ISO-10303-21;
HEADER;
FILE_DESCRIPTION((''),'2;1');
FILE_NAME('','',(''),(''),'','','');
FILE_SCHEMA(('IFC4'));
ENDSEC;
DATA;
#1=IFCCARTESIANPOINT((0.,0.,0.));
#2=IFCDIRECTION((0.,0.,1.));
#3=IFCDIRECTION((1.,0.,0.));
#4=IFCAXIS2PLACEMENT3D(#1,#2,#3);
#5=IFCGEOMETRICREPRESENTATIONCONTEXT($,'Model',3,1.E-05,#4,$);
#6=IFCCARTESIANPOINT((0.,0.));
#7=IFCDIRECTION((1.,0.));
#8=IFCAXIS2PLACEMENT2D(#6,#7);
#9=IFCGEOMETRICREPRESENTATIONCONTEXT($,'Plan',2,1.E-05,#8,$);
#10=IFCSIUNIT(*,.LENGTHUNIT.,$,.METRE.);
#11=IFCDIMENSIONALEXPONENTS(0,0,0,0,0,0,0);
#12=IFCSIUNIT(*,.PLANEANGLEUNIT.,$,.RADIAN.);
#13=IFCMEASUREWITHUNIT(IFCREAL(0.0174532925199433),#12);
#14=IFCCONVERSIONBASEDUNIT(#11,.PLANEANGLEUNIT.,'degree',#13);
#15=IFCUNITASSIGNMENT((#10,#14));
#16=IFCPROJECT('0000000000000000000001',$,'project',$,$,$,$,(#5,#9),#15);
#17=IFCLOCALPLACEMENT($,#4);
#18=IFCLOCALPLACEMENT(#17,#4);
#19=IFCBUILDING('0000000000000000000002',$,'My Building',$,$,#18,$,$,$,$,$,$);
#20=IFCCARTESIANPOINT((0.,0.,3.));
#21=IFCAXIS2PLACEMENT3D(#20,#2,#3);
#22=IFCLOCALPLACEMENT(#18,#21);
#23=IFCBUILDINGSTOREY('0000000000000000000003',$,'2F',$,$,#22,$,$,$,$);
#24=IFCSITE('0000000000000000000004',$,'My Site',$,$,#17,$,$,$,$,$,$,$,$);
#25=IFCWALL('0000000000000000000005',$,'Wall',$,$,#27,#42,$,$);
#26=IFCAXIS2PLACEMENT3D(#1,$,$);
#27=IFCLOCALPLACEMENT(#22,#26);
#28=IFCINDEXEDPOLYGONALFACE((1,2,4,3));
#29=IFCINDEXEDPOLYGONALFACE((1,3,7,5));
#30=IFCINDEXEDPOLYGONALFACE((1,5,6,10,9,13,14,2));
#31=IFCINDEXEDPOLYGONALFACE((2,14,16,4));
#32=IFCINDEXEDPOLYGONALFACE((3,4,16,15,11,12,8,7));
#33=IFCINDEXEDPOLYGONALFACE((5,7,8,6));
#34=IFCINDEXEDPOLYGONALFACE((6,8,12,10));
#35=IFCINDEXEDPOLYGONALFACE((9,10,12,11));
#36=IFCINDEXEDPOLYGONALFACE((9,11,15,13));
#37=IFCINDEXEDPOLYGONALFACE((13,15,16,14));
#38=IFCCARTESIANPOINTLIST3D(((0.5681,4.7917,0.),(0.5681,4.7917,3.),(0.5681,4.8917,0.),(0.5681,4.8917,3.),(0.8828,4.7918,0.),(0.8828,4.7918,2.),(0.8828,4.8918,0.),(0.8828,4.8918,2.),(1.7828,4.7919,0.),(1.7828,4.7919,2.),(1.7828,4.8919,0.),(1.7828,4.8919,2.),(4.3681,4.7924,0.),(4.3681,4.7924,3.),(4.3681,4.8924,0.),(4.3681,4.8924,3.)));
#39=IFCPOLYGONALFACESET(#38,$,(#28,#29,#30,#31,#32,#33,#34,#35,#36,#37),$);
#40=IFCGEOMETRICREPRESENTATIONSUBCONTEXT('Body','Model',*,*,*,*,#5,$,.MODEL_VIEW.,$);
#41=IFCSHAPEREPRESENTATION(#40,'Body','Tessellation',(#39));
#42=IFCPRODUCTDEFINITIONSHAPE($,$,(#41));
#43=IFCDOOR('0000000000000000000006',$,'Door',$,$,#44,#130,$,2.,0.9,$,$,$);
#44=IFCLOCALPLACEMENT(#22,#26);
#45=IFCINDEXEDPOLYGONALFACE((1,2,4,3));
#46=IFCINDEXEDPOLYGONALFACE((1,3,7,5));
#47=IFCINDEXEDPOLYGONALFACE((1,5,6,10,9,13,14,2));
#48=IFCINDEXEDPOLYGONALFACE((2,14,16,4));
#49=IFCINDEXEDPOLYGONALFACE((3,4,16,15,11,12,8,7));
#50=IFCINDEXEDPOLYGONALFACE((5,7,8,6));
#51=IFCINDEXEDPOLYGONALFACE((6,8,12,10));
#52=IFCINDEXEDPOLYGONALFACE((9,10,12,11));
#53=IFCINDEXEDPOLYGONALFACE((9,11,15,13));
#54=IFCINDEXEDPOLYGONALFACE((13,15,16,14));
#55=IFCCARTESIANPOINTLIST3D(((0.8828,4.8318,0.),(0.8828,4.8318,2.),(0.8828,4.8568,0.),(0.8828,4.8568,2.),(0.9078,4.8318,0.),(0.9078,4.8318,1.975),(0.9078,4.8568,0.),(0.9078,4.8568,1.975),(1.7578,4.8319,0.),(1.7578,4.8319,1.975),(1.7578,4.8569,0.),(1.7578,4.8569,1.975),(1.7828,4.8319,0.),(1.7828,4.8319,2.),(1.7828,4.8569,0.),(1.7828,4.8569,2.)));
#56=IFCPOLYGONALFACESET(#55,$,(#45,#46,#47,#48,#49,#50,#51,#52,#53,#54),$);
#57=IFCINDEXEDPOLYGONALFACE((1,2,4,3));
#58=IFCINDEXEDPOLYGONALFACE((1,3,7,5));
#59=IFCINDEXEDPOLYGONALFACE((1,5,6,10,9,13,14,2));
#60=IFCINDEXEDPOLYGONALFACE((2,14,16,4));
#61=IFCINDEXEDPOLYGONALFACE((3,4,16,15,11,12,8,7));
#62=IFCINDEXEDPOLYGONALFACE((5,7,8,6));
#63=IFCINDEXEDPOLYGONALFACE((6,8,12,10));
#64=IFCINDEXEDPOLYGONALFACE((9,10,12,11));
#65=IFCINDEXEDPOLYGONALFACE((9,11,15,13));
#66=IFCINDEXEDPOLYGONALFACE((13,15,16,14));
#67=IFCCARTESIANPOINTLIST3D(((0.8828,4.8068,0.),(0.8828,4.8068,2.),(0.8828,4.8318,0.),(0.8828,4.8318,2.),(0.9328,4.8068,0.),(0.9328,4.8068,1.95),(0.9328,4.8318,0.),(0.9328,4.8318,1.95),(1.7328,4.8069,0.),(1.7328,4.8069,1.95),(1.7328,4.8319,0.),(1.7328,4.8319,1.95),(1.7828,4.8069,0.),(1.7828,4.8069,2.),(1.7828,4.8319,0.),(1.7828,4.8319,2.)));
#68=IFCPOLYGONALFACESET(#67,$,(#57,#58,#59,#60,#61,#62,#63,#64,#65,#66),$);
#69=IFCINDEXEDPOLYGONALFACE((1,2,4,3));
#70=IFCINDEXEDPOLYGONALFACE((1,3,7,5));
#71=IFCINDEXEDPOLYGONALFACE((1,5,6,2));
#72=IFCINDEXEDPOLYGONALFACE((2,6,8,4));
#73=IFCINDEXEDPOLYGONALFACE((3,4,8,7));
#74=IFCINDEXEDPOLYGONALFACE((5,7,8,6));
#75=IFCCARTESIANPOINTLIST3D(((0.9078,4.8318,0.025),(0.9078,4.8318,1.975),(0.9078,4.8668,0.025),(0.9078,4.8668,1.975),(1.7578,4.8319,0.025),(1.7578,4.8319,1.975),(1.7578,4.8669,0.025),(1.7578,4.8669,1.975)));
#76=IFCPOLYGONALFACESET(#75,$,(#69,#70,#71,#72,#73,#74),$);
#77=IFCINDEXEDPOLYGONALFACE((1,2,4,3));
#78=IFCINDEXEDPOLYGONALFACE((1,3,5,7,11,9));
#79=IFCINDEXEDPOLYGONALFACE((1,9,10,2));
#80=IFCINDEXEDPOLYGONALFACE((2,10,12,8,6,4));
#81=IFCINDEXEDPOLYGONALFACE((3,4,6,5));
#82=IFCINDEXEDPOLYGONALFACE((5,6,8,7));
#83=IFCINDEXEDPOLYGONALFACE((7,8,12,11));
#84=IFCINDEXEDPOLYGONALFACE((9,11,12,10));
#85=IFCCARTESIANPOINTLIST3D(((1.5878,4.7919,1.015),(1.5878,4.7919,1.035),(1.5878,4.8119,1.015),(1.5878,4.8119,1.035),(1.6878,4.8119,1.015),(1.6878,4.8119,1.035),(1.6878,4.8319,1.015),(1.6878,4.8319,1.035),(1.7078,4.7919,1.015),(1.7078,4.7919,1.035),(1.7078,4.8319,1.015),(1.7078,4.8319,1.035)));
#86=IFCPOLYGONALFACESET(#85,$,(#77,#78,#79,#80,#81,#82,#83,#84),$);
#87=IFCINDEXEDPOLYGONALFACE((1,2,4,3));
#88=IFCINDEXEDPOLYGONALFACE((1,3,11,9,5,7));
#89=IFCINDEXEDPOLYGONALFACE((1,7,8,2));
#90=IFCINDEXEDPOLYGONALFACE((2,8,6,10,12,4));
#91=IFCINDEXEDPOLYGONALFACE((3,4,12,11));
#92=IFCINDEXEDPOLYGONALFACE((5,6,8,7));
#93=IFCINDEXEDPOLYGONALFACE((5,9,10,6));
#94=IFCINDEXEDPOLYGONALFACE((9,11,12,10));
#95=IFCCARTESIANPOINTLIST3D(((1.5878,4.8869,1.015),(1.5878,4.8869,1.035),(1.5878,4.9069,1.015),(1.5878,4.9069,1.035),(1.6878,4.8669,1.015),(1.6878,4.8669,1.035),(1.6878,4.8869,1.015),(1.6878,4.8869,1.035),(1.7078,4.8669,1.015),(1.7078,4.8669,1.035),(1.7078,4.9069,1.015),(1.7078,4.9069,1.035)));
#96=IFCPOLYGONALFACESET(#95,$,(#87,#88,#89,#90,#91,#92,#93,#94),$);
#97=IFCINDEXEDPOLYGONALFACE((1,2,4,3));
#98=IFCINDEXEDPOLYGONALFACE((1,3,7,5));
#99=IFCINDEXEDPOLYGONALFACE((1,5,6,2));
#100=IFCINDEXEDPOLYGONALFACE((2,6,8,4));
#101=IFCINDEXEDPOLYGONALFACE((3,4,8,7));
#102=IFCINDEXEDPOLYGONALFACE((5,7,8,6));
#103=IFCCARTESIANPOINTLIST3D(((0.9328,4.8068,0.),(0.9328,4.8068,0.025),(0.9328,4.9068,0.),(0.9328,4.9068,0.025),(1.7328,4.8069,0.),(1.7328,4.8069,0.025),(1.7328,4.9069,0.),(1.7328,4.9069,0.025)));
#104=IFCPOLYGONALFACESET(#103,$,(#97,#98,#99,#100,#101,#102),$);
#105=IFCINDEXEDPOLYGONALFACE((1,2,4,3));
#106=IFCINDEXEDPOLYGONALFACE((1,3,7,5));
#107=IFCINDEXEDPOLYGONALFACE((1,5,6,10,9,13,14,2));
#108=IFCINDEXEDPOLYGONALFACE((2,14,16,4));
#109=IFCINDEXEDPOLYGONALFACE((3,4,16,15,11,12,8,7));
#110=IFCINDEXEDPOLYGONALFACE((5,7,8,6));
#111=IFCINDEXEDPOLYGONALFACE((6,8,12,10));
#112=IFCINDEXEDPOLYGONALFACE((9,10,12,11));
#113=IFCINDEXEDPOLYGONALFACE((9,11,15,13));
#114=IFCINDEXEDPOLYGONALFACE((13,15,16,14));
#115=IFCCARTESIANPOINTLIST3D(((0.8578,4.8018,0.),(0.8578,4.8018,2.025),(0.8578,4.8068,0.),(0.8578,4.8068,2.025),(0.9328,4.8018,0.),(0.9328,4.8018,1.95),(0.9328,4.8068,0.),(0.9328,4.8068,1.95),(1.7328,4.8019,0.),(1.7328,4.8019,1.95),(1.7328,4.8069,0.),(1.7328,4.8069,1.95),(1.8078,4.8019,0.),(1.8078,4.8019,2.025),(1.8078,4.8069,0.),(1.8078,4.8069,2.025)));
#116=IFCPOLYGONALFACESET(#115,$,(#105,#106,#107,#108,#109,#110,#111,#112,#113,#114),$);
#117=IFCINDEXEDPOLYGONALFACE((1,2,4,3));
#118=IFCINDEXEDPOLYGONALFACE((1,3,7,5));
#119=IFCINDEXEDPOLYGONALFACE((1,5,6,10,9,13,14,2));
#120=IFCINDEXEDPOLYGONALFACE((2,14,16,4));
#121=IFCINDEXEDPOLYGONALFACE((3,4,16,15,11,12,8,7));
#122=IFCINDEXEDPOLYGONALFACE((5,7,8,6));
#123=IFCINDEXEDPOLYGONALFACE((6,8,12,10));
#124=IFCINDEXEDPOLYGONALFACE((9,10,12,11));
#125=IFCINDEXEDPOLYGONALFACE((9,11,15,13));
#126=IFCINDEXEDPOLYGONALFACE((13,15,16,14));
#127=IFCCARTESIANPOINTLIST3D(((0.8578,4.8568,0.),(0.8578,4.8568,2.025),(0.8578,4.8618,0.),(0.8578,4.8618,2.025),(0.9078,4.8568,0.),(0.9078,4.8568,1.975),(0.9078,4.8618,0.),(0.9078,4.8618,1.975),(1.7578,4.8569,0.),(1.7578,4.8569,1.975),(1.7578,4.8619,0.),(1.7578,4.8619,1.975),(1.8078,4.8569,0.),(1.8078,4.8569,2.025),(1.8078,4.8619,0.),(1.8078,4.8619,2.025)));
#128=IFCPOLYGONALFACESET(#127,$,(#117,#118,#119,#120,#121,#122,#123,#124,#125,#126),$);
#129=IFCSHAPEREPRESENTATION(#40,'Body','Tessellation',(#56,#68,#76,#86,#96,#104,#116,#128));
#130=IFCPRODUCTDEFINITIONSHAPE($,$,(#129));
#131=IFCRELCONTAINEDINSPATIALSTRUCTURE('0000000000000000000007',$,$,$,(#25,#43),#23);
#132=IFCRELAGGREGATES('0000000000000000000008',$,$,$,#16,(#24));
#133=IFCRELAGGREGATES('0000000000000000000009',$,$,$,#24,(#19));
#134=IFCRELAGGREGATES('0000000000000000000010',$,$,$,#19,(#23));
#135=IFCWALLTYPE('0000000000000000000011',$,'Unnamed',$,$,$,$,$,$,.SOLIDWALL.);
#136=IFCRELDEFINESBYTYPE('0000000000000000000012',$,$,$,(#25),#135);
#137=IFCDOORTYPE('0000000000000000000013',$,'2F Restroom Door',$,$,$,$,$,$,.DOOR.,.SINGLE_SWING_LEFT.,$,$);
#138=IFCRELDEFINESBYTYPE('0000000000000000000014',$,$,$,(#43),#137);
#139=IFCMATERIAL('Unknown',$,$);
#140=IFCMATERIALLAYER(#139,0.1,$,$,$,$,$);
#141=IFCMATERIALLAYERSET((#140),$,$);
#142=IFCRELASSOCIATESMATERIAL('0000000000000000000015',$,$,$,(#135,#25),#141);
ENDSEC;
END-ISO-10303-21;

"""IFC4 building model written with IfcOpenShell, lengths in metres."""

from ifc_helpers import new_model, entity, si_unit, converted_unit, frame, origin_with_axes, origin_2d_with_axis, place, context, subcontext, project, spatial, line, indexed_curve, outline, extrude, shape, source, transform, mapped, material, layer, layer_set, layer_usage, type_object, type_shapes, element, fill, save


model = new_model("IFC4")

# Units and contexts
model_context = context("Model", 3, precision=1e-05, world=origin_with_axes())
plan_context = context("Plan", 2, precision=1e-05, world=origin_2d_with_axis())
body_context_1 = subcontext(model_context, "Body", "Model", "MODEL_VIEW")
body_context_2 = subcontext(plan_context, "Body", "Plan", "PLAN_VIEW")
ifc_project = project(units=[si_unit("LENGTHUNIT", "METRE"), converted_unit("PLANEANGLEUNIT", "degree", entity("IfcReal", 0.0174532925199433), si_unit("PLANEANGLEUNIT", "RADIAN"), dimensions=[0, 0, 0, 0, 0, 0, 0])], contexts=[model_context, plan_context])

# Site, building, storey
site_placement = place(None, origin_with_axes())
site = spatial("IfcSite", under=ifc_project, at=site_placement, Name="My Site")
building_placement = place(site_placement, origin_with_axes())
building = spatial("IfcBuilding", under=site, at=building_placement, Name="My Building")
storey_placement = place(building_placement, frame((0.0, 0.0, 3.0), z_axis=(0.0, 0.0, 1.0), x_axis=(1.0, 0.0, 0.0)))
storey = spatial("IfcBuildingStorey", under=building, at=storey_placement, Name="2F")

# Shared definitions
ifc_material = material(Name="Unknown")

# Shared definitions
ifc_layer = layer(ifc_material, 0.1)
ifc_layer_set = layer_set([ifc_layer])
wall_type = type_object("IfcWallType", Name="Unnamed", PredefinedType="SOLIDWALL", material=ifc_layer_set)

# Wall, opening, door
ifc_layer_usage_1 = layer_usage(ifc_layer_set, "AXIS2", "POSITIVE", 0.0)
wall_1_placement = place(storey_placement, frame((4.3681, 4.8924, 0.0), z_axis=(0.0, 0.0, 1.0), x_axis=(-1.0, -0.000193, 0.0)))
wall_1 = element("IfcWall", 1, at=wall_1_placement, inside=storey, type_object=wall_type, material=ifc_layer_usage_1, Name="Wall", context=body_context_1, shape_type="SweptSolid", body=[
    extrude(outline(indexed_curve([(0.0, 0.0), (0.0, 0.1), (3.8, 0.1), (3.8, 0.0)], segments=[line(1, 2, 3, 4, 1)])), origin_with_axes(), (0.0, 0.0, 1.0), 3.0),
])
shared_shape_1 = source(origin_with_axes(), body_context_1, "Body", "SweptSolid", [
    extrude(outline(indexed_curve([(0.0, 0.0), (0.9, 0.0), (0.9, 2.0), (0.0, 2.0)], segments=[line(1, 2, 3, 4, 1)])), frame((0.0, -0.6, 0.0), z_axis=(0.0, -1.0, 0.0), x_axis=(1.0, 0.0, 0.0)), (0.0, 0.0, -1.0), 1.2),
])
opening_1_placement = place(wall_1_placement, frame((2.5853, 0.0, 0.0), z_axis=(0.0, 0.0, 1.0), x_axis=(1.0, 0.0, 0.0)))
opening_1 = element("IfcOpeningElement", 2, at=opening_1_placement, cuts=wall_1, PredefinedType="OPENING", context=body_context_1, shape_type="MappedRepresentation", body=[
    mapped(shared_shape_1, transform((0.0, 0.0, 0.0), x_axis=(1.0, 0.0, 0.0), y_axis=(0.0, 1.0, 0.0), z_axis=(0.0, 0.0, 1.0), scale=1.0)),
])
door_type_1 = type_object("IfcDoorType", Name="2F Restroom Door", OperationType="SINGLE_SWING_LEFT", PredefinedType="DOOR")
shared_shape_2 = source(origin_with_axes(), body_context_1, "Body", "SweptSolid", [
    extrude(outline(indexed_curve([(0.0, 0.0), (0.0, 2.0), (0.9, 2.0), (0.9, 0.0), (0.875, 0.0), (0.875, 1.975), (0.025, 1.975), (0.025, 0.0)], segments=[line(1, 2, 3, 4, 5, 6, 7, 8, 1)])), frame((0.0, 0.025, 0.0), z_axis=(0.0, -1.0, 0.0), x_axis=(1.0, 0.0, 0.0)), (0.0, 0.0, -1.0), 0.025),
    extrude(outline(indexed_curve([(0.0, 0.0), (0.0, 2.0), (0.9, 2.0), (0.9, 0.0), (0.85, 0.0), (0.85, 1.95), (0.05, 1.95), (0.05, 0.0)], segments=[line(1, 2, 3, 4, 5, 6, 7, 8, 1)])), frame((0.0, 0.0, 0.0), z_axis=(0.0, -1.0, 0.0), x_axis=(1.0, 0.0, 0.0)), (0.0, 0.0, -1.0), 0.025),
    extrude(outline(indexed_curve([(0.0, 0.0), (0.85, 0.0), (0.85, 0.035), (0.0, 0.035)], segments=[line(1, 2, 3, 4, 1)])), frame((0.025, 0.025, 0.025), z_axis=(0.0, 0.0, 1.0), x_axis=(1.0, 0.0, 0.0)), (0.0, 0.0, 1.0), 1.95),
    extrude(outline(indexed_curve([(0.0, 0.0), (0.0, -0.04), (-0.12, -0.04), (-0.12, -0.02), (-0.02, -0.02), (-0.02, 0.0)], segments=[line(1, 2, 3, 4, 5, 6, 1)])), frame((0.825, 0.025, 1.015), z_axis=(0.0, 0.0, 1.0), x_axis=(1.0, 0.0, 0.0)), (0.0, 0.0, 1.0), 0.02),
    extrude(outline(indexed_curve([(0.0, 0.0), (0.0, 0.04), (-0.12, 0.04), (-0.12, 0.02), (-0.02, 0.02), (-0.02, 0.0)], segments=[line(1, 2, 3, 4, 5, 6, 1)])), frame((0.825, 0.06, 1.015), z_axis=(0.0, 0.0, 1.0), x_axis=(1.0, 0.0, 0.0)), (0.0, 0.0, 1.0), 0.02),
    extrude(outline(indexed_curve([(0.0, 0.0), (0.8, 0.0), (0.8, 0.1), (0.0, 0.1)], segments=[line(1, 2, 3, 4, 1)])), frame((0.05, 0.0, 0.0), z_axis=(0.0, 0.0, 1.0), x_axis=(1.0, 0.0, 0.0)), (0.0, 0.0, 1.0), 0.025),
    extrude(outline(indexed_curve([(0.0, 0.0), (0.0, 2.025), (0.95, 2.025), (0.95, 0.0), (0.875, 0.0), (0.875, 1.95), (0.075, 1.95), (0.075, 0.0)], segments=[line(1, 2, 3, 4, 5, 6, 7, 8, 1)])), frame((-0.025, -0.005, 0.0), z_axis=(0.0, -1.0, 0.0), x_axis=(1.0, 0.0, 0.0)), (0.0, 0.0, -1.0), 0.005),
    extrude(outline(indexed_curve([(0.0, 0.0), (0.0, 2.025), (0.95, 2.025), (0.95, 0.0), (0.9, 0.0), (0.9, 1.975), (0.05, 1.975), (0.05, 0.0)], segments=[line(1, 2, 3, 4, 5, 6, 7, 8, 1)])), frame((-0.025, 0.05, 0.0), z_axis=(0.0, -1.0, 0.0), x_axis=(1.0, 0.0, 0.0)), (0.0, 0.0, -1.0), 0.005),
])
shared_shape_3 = source(origin_with_axes(), body_context_2, "Body", "Curve2D", [
    entity("IfcIndexedPolyCurve", entity("IfcCartesianPointList2D", [[0.0, 0.0], [0.0, 0.05], [0.025, 0.05], [0.025, 0.025], [0.05, 0.025], [0.05, 0.0]]), [entity("IfcLineIndex", [1, 2, 3, 4, 5, 6, 1])]),
    entity("IfcIndexedPolyCurve", entity("IfcCartesianPointList2D", [[0.9, 0.0], [0.9, 0.05], [0.875, 0.05], [0.875, 0.025], [0.85, 0.025], [0.85, 0.0]]), [entity("IfcLineIndex", [1, 2, 3, 4, 5, 6, 1])]),
    entity("IfcTrimmedCurve", entity("IfcEllipse", entity("IfcAxis2Placement2D", entity("IfcCartesianPoint", [0.06, 0.05]), entity("IfcDirection", [1.0, 0.0])), 0.815, 0.85), [entity("IfcCartesianPoint", [0.875, 0.05])], [entity("IfcCartesianPoint", [0.06, 0.9])], True, "CARTESIAN"),
    entity("IfcIndexedPolyCurve", entity("IfcCartesianPointList2D", [[0.025, 0.05], [0.06, 0.05], [0.06, 0.9], [0.025, 0.9]]), [entity("IfcLineIndex", [1, 2, 3, 4, 1])]),
])
type_shapes(door_type_1, [shared_shape_2, shared_shape_3])
door_1_placement = place(opening_1_placement, frame((0.9, 0.085, 0.0), z_axis=(0.0, 0.0, 1.0), x_axis=(-1.0, 0.0, 0.0)))
door_1 = element("IfcDoor", 3, at=door_1_placement, inside=storey, type_object=door_type_1, Name="Door", OverallHeight=2.0, OverallWidth=0.9, shapes=[
    shape(body_context_1, "Body", "MappedRepresentation", [mapped(shared_shape_2, transform((0.0, 0.0, 0.0), x_axis=(1.0, 0.0, 0.0), y_axis=(0.0, 1.0, 0.0), z_axis=(0.0, 0.0, 1.0), scale=1.0))]),
    shape(body_context_2, "Body", "MappedRepresentation", [mapped(shared_shape_3, transform((0.0, 0.0, 0.0), x_axis=(1.0, 0.0, 0.0), y_axis=(0.0, 1.0, 0.0), z_axis=(0.0, 0.0, 1.0), scale=1.0))]),
])
fill(opening_1, door_1)

save(model, "model.ifc")
